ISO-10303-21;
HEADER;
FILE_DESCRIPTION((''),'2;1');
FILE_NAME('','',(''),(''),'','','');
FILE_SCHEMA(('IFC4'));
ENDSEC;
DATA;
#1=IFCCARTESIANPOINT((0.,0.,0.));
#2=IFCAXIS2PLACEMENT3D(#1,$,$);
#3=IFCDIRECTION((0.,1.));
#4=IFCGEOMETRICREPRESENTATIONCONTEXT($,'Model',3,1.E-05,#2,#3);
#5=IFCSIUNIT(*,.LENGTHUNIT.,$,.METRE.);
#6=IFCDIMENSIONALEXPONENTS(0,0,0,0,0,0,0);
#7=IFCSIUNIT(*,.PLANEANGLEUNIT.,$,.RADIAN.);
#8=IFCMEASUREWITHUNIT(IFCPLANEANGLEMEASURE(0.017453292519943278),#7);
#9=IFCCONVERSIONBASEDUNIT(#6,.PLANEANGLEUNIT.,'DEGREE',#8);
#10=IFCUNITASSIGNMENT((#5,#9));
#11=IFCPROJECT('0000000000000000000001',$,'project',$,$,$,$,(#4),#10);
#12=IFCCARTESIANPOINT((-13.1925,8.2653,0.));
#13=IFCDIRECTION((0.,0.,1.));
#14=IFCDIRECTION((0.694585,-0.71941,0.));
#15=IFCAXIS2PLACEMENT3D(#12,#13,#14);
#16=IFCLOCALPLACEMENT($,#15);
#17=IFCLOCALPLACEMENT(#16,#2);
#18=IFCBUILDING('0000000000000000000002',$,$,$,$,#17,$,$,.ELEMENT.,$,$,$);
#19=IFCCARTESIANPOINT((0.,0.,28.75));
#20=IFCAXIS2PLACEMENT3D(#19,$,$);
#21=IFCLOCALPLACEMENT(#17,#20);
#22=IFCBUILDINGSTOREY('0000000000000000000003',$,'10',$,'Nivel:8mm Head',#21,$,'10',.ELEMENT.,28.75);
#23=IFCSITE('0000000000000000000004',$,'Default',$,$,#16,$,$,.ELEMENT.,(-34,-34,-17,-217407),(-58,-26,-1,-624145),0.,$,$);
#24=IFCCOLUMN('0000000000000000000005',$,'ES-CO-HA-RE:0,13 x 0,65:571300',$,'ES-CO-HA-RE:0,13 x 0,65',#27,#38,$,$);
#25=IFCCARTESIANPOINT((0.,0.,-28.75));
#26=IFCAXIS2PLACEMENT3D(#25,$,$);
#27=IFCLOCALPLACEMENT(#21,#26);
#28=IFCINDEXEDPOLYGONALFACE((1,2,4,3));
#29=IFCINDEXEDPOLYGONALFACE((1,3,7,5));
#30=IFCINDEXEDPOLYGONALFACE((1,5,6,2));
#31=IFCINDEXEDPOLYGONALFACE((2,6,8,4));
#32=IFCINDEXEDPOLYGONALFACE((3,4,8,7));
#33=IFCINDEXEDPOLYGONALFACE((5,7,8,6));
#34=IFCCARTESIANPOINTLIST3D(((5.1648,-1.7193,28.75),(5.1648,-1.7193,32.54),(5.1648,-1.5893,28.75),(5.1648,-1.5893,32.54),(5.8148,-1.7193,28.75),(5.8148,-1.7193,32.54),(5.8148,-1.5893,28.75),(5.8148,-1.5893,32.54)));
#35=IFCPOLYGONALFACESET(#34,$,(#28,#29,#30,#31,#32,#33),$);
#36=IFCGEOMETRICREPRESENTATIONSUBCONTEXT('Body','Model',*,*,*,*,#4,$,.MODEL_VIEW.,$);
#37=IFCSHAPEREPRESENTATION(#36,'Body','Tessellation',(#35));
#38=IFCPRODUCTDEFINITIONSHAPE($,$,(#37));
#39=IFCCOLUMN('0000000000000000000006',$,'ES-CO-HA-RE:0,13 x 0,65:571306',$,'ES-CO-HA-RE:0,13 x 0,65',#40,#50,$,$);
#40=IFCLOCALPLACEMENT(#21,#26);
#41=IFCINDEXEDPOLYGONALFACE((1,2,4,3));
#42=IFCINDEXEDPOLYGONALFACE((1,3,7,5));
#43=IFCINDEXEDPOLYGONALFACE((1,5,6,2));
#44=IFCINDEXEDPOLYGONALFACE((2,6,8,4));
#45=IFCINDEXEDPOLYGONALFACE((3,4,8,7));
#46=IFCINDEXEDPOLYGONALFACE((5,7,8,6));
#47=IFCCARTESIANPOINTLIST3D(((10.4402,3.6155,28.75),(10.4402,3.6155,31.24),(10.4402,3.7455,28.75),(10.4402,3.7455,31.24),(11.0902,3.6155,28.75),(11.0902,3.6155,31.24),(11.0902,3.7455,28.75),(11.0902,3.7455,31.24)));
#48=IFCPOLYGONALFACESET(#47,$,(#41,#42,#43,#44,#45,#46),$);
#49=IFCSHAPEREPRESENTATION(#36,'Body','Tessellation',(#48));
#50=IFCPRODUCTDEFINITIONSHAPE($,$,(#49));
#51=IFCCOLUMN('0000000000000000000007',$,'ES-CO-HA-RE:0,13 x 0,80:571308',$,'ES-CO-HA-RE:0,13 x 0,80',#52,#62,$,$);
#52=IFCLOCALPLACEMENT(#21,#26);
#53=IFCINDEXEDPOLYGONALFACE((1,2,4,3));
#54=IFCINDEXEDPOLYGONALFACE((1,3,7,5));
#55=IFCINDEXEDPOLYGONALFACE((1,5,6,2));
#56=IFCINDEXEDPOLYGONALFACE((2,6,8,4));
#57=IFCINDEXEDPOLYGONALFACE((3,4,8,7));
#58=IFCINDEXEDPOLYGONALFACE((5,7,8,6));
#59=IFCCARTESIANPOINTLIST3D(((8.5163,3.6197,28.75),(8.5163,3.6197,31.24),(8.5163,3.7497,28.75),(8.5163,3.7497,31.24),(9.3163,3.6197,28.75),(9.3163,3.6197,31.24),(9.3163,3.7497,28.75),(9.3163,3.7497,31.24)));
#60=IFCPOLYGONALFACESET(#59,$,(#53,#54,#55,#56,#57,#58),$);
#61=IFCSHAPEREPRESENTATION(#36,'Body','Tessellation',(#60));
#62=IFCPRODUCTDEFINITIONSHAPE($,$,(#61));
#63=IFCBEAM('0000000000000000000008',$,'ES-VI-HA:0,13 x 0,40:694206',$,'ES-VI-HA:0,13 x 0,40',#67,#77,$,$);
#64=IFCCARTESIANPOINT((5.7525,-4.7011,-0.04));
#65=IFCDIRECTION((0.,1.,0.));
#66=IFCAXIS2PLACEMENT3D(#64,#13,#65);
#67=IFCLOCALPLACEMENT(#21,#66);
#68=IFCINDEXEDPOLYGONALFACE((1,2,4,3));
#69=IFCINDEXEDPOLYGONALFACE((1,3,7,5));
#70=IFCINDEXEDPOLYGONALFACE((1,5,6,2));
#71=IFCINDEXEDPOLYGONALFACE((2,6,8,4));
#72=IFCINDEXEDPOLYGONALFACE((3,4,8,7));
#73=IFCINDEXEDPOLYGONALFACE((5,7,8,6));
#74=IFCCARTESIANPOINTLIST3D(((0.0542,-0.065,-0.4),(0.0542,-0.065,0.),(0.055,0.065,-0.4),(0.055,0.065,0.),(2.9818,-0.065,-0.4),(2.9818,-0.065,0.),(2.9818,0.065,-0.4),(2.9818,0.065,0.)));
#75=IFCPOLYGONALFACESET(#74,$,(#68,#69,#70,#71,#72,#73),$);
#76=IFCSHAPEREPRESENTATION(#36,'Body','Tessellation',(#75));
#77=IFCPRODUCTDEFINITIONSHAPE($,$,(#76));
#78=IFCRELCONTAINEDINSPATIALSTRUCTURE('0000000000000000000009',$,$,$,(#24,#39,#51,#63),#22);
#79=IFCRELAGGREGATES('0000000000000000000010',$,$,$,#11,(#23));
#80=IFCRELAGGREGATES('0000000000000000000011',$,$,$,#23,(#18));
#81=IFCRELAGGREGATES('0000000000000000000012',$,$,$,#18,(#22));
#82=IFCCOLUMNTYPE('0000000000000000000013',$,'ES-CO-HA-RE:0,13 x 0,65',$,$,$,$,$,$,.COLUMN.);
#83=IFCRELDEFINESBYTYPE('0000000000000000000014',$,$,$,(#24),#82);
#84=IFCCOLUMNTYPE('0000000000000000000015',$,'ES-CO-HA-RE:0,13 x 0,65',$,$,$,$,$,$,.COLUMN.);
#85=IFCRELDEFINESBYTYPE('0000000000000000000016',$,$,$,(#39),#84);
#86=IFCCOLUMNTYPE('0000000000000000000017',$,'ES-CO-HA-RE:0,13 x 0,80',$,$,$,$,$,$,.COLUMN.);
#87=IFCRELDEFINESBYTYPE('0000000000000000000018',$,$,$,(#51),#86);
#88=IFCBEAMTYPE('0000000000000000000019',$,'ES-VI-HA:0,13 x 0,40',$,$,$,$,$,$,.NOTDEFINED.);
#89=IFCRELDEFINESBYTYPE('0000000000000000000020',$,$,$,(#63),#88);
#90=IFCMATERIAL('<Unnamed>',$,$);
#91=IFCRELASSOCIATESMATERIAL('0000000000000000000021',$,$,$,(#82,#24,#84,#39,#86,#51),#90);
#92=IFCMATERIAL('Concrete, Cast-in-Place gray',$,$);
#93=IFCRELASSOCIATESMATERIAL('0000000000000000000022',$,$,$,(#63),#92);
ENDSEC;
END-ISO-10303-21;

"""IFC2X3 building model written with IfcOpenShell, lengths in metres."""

from ifc_helpers import new_model, entity, si_unit, converted_unit, direction, frame, frame_2d, origin, origin_2d_with_axis, place, context, subcontext, project, spatial, rectangle, extrude, clip, halfspace, source, transform, mapped, material, type_object, type_shapes, element, save


model = new_model("IFC2X3")

# Units and contexts
model_context = context("Model", 3, precision=1e-05, world=origin(), true_north=direction((0.0, 1.0)))
body_context = subcontext(model_context, "Body", "Model", "MODEL_VIEW")
ifc_project = project(units=[si_unit("LENGTHUNIT", "METRE"), converted_unit("PLANEANGLEUNIT", "DEGREE", entity("IfcPlaneAngleMeasure", 0.017453292519943278), si_unit("PLANEANGLEUNIT", "RADIAN"), dimensions=[0, 0, 0, 0, 0, 0, 0])], contexts=[model_context])

# Site, building, storey
site_placement = place(None, frame((-13.1925, 8.2653, 0.0), z_axis=(0.0, 0.0, 1.0), x_axis=(0.694585, -0.71941, 0.0)))
site = spatial("IfcSite", under=ifc_project, at=site_placement, Name="Default", CompositionType="ELEMENT", RefLatitude=(-34, -34, -17, -217407), RefLongitude=(-58, -26, -1, -624145), RefElevation=0.0)
building_placement = place(site_placement, origin())
building = spatial("IfcBuilding", under=site, at=building_placement, CompositionType="ELEMENT")
storey_placement = place(building_placement, frame((0.0, 0.0, 28.75)))
storey = spatial("IfcBuildingStorey", under=building, at=storey_placement, Name="10", ObjectType="Nivel:8mm Head", LongName="10", CompositionType="ELEMENT", Elevation=28.75)

# Columns
ifc_material_1 = material(Name="<Unnamed>")
column_type_1 = type_object("IfcColumnType", Name="ES-CO-HA-RE:0,13 x 0,65", PredefinedType="COLUMN", material=ifc_material_1)
shared_shape_1 = source(origin(), body_context, "Body", "SweptSolid", [
    extrude(rectangle(XDim=0.65, YDim=0.13, at=frame_2d((0.0, 0.0), x_axis=(1.0, 0.0))), frame((5.4898, -1.6543, 28.75), z_axis=(0.0, 0.0, 1.0), x_axis=(-1.0, 0.0, 0.0)), (0.0, 0.0, 1.0), 3.79),
])
type_shapes(column_type_1, [shared_shape_1])
column_1_placement = place(storey_placement, frame((0.0, 0.0, -28.75)))
element("IfcColumn", 1, at=column_1_placement, inside=storey, type_object=column_type_1, material=ifc_material_1, Name="ES-CO-HA-RE:0,13 x 0,65:571300", ObjectType="ES-CO-HA-RE:0,13 x 0,65", context=body_context, shape_type="MappedRepresentation", body=[
    mapped(shared_shape_1, transform((0.0, 0.0, 0.0), scale=1.0)),
])
column_type_2 = type_object("IfcColumnType", Name="ES-CO-HA-RE:0,13 x 0,65", PredefinedType="COLUMN", material=ifc_material_1)
shared_shape_2 = source(origin(), body_context, "Body", "SweptSolid", [
    extrude(rectangle(XDim=0.65, YDim=0.13, at=origin_2d_with_axis()), frame((10.7652, 3.6805, 28.75), z_axis=(0.0, 0.0, 1.0), x_axis=(-1.0, 0.0, 0.0)), (0.0, 0.0, 1.0), 2.49),
])
type_shapes(column_type_2, [shared_shape_2])
column_2_placement = place(storey_placement, frame((0.0, 0.0, -28.75)))
element("IfcColumn", 2, at=column_2_placement, inside=storey, type_object=column_type_2, material=ifc_material_1, Name="ES-CO-HA-RE:0,13 x 0,65:571306", ObjectType="ES-CO-HA-RE:0,13 x 0,65", context=body_context, shape_type="MappedRepresentation", body=[
    mapped(shared_shape_2, transform((0.0, 0.0, 0.0), scale=1.0)),
])
column_type_3 = type_object("IfcColumnType", Name="ES-CO-HA-RE:0,13 x 0,80", PredefinedType="COLUMN", material=ifc_material_1)
shared_shape_3 = source(origin(), body_context, "Body", "SweptSolid", [
    extrude(rectangle(XDim=0.8, YDim=0.13, at=origin_2d_with_axis()), frame((8.9163, 3.6847, 28.75), z_axis=(0.0, 0.0, 1.0), x_axis=(-1.0, 0.0, 0.0)), (0.0, 0.0, 1.0), 2.49),
])
type_shapes(column_type_3, [shared_shape_3])
column_3_placement = place(storey_placement, frame((0.0, 0.0, -28.75)))
element("IfcColumn", 3, at=column_3_placement, inside=storey, type_object=column_type_3, material=ifc_material_1, Name="ES-CO-HA-RE:0,13 x 0,80:571308", ObjectType="ES-CO-HA-RE:0,13 x 0,80", context=body_context, shape_type="MappedRepresentation", body=[
    mapped(shared_shape_3, transform((0.0, 0.0, 0.0), scale=1.0)),
])

# Beam
ifc_material_2 = material(Name="Concrete, Cast-in-Place gray")
beam_type_1 = type_object("IfcBeamType", Name="ES-VI-HA:0,13 x 0,40", PredefinedType="NOTDEFINED")
beam_1_placement = place(storey_placement, frame((5.7525, -4.7011, -0.04), z_axis=(0.0, 0.0, 1.0), x_axis=(0.0, 1.0, 0.0)))
element("IfcBeam", 4, at=beam_1_placement, inside=storey, type_object=beam_type_1, material=ifc_material_2, Name="ES-VI-HA:0,13 x 0,40:694206", ObjectType="ES-VI-HA:0,13 x 0,40", context=body_context, shape_type="SweptSolid", body=[
    clip(extrude(rectangle(XDim=0.4, YDim=0.13, at=frame_2d((0.0, 0.0), x_axis=(1.0, 0.0))), frame((0.0542, 0.0, -0.2), z_axis=(1.0, 0.0, 0.0), x_axis=(0.0, 0.0, -1.0)), (0.0, 0.0, 1.0), 2.9275), halfspace(frame((0.052, -0.4718, -0.5), z_axis=(-0.999984, 0.005619, 0.0), x_axis=(0.005619, 0.999984, 0.0)), False)),
])

save(model, "model.ifc")
